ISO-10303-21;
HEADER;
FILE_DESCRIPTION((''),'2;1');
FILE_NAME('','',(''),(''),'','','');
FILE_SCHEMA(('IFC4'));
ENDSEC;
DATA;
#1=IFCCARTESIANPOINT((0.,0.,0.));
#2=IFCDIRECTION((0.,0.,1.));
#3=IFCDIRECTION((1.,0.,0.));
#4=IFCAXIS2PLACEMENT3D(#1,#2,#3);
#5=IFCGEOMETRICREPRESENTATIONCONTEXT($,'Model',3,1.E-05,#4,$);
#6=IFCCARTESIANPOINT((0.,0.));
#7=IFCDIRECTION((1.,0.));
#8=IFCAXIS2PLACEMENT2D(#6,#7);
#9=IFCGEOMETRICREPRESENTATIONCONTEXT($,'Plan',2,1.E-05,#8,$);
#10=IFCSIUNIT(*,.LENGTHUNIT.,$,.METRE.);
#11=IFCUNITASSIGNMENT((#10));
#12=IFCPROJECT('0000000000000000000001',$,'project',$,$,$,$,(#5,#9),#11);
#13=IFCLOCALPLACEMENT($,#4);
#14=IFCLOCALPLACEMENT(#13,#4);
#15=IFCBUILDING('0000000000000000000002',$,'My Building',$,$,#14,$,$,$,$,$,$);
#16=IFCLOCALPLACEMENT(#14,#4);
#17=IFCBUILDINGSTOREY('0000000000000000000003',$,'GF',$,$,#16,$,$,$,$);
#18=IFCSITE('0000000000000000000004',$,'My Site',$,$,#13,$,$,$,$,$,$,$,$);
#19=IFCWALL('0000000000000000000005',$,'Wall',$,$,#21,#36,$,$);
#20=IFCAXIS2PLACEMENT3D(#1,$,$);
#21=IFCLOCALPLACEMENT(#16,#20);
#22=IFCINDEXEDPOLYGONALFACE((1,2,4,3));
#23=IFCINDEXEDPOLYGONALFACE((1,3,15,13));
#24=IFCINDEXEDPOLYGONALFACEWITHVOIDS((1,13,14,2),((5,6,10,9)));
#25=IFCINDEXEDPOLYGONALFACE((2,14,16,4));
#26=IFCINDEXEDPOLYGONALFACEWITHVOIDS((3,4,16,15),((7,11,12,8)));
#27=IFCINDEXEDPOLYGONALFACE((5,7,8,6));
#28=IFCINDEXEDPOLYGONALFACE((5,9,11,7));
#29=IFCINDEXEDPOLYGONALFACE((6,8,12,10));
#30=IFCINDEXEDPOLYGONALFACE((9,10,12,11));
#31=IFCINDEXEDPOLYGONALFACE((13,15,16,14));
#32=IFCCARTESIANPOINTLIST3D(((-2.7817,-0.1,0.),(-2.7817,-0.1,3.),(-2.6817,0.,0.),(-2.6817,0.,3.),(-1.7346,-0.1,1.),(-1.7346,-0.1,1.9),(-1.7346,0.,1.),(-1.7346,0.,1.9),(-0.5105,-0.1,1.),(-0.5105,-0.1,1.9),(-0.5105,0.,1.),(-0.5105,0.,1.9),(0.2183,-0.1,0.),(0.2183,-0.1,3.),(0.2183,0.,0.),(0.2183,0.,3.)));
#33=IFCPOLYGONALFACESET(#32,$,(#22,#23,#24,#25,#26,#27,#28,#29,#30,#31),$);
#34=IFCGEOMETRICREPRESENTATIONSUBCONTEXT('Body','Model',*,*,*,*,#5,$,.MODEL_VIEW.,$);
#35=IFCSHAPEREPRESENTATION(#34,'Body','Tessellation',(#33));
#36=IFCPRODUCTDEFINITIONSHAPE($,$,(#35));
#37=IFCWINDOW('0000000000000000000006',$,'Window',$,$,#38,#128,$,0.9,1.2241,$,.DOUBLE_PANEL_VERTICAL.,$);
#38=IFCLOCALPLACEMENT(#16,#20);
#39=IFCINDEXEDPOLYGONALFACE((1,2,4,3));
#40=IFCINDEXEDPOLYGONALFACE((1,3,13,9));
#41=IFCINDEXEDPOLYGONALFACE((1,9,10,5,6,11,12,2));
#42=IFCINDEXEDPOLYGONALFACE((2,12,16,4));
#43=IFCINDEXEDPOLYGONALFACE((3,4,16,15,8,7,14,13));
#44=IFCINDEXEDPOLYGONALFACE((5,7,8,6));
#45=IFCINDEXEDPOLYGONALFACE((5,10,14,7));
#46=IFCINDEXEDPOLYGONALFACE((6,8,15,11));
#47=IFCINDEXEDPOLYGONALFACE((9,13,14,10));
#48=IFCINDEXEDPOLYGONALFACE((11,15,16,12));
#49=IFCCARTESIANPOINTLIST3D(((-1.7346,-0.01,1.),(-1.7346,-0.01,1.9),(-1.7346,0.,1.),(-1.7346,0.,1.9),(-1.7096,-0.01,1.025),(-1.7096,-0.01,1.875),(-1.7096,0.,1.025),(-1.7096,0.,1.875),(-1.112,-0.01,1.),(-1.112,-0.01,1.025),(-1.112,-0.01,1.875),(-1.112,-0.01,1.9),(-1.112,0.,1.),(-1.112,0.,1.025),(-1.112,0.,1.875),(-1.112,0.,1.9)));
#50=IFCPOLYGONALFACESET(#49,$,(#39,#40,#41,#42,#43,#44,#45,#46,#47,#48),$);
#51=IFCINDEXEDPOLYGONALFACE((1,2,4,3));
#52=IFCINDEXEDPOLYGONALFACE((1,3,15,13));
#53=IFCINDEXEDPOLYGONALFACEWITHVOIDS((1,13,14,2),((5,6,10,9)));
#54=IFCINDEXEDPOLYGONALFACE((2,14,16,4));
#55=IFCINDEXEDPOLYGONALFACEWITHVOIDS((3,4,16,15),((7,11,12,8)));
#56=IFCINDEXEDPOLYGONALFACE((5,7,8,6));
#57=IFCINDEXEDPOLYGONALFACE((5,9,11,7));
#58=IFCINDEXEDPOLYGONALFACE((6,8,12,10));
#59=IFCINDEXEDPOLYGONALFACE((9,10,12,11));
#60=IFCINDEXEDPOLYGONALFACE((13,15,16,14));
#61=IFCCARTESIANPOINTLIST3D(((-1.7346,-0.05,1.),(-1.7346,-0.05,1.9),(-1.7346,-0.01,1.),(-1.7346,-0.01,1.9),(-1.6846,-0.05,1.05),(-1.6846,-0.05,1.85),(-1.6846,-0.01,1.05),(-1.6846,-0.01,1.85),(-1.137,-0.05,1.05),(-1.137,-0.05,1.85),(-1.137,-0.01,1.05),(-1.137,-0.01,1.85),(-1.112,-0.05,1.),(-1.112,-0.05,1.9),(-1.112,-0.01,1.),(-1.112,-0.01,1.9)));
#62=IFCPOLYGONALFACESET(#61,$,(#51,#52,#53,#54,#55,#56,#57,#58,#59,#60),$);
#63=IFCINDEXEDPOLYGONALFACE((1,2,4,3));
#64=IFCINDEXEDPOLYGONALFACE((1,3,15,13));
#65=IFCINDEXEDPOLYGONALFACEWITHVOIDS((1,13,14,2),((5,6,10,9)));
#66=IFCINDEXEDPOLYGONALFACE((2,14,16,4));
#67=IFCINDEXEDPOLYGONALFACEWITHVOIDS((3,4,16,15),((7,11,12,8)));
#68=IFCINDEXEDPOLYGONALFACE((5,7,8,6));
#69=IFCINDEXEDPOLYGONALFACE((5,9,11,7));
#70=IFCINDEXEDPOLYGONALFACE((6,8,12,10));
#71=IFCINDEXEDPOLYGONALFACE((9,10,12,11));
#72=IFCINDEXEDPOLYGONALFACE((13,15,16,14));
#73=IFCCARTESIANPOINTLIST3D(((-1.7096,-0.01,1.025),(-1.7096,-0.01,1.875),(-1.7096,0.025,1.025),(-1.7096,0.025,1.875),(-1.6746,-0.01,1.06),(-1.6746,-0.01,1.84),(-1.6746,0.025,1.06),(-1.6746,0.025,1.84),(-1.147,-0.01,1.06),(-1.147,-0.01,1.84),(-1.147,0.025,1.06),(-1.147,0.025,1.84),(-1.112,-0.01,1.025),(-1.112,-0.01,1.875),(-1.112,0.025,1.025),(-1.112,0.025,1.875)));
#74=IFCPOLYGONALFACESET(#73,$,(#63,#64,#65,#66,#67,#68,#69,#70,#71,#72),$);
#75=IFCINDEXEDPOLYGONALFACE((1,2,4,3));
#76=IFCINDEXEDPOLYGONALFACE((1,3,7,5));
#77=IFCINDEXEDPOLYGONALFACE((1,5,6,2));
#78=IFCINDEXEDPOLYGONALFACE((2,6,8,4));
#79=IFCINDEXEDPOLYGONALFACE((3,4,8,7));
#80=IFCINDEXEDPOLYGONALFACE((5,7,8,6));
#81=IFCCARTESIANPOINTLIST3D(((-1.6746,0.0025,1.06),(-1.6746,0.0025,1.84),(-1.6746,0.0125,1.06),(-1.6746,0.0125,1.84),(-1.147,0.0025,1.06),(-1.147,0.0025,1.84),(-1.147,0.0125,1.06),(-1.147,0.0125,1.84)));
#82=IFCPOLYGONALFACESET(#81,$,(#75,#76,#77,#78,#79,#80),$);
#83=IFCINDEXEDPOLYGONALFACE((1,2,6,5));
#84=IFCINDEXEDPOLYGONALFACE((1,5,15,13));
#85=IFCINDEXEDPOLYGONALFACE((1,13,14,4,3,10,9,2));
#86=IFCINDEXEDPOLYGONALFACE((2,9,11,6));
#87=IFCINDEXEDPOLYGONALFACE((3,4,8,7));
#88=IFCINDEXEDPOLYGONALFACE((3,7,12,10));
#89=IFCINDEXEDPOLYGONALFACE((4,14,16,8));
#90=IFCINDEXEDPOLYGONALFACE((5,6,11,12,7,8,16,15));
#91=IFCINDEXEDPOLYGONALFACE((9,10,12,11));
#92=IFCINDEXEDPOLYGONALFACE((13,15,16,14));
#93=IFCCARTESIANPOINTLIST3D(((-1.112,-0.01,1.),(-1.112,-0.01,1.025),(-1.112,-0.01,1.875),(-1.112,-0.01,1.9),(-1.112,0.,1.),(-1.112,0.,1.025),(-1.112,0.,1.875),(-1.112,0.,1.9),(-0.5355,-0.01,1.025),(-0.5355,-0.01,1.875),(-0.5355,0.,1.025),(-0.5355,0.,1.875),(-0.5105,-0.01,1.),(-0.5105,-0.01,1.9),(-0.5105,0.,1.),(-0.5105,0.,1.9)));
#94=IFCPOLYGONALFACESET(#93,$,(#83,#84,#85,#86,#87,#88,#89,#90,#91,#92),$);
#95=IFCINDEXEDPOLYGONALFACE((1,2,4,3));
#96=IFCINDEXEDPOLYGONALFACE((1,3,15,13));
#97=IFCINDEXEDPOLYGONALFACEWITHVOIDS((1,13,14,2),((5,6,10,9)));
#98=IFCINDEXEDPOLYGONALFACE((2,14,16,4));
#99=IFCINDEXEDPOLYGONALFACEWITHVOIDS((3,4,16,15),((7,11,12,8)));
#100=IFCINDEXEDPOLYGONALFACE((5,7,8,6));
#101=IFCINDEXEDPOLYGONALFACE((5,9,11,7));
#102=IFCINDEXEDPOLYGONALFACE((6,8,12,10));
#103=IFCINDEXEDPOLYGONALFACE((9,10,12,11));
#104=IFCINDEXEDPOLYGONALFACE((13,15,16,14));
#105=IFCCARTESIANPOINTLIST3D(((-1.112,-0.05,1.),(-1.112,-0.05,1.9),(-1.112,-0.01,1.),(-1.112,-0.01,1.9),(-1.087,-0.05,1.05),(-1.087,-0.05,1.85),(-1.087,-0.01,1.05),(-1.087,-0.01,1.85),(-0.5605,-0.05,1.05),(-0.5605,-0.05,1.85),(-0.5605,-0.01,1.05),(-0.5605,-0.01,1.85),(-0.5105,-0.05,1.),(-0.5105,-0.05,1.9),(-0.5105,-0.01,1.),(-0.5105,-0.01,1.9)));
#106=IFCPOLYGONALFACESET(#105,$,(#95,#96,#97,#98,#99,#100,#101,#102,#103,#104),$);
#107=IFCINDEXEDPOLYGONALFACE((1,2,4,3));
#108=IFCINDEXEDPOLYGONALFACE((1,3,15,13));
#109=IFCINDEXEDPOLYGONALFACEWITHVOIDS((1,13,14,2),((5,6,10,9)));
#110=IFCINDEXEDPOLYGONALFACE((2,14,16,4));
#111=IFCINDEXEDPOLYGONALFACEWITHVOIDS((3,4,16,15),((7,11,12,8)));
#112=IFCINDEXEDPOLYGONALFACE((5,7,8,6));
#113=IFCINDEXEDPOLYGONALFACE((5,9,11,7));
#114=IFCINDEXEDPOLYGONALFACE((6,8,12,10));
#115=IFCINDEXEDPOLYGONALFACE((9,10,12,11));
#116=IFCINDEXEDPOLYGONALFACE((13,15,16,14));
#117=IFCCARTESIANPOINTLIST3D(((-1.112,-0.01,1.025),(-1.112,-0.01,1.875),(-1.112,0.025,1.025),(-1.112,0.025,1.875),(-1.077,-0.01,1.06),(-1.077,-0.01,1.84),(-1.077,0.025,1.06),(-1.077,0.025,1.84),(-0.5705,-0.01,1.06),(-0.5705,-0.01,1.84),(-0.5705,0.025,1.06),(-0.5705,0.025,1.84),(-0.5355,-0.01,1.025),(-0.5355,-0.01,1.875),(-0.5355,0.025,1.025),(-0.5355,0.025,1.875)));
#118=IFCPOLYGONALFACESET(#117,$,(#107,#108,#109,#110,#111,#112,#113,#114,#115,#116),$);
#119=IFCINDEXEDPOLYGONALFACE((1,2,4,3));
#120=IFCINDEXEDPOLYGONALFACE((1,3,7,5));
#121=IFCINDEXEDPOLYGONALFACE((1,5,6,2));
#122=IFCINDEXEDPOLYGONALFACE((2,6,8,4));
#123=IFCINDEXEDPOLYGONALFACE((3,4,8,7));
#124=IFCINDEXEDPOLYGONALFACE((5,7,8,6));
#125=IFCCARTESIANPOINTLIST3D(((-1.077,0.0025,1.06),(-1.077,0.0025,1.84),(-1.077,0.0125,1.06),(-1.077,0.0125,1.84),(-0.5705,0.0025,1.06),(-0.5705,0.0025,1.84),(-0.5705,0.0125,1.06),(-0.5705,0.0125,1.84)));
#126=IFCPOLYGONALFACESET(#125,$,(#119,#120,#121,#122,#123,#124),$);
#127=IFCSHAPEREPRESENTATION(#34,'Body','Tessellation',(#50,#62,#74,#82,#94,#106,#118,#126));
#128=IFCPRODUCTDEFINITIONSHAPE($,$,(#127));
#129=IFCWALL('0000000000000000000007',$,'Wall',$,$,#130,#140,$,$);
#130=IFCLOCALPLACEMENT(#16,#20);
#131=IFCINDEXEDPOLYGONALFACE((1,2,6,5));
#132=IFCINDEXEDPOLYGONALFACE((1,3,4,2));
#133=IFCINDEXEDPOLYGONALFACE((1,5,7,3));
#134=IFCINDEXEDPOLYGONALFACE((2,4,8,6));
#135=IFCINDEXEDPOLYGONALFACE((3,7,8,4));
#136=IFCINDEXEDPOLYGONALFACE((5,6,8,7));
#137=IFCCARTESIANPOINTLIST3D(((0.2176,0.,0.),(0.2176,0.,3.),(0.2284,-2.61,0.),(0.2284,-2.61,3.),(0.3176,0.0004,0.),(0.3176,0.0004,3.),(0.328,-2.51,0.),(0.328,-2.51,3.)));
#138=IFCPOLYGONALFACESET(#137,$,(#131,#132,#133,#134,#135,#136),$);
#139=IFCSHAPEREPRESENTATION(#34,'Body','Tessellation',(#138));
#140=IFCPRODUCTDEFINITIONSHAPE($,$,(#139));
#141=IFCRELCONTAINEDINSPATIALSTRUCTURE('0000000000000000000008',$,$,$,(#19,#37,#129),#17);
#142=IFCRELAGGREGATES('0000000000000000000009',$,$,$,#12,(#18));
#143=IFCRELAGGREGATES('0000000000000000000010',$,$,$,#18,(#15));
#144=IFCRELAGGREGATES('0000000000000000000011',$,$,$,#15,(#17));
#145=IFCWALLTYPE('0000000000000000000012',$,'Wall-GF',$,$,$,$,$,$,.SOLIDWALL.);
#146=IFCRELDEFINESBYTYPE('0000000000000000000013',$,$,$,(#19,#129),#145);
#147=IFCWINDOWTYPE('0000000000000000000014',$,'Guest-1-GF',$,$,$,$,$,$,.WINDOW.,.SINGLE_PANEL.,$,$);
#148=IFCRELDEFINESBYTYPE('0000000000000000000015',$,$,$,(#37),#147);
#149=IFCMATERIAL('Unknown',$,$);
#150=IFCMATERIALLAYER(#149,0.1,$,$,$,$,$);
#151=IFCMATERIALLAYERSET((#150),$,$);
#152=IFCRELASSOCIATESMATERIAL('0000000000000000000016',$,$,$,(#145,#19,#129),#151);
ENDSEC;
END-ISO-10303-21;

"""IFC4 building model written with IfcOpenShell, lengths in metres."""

from ifc_helpers import new_model, entity, si_unit, frame, origin_with_axes, origin_2d_with_axis, place, context, subcontext, project, spatial, line, indexed_curve, outline, extrude, shape, source, transform, mapped, material, layer, layer_set, layer_usage, type_object, type_shapes, element, fill, save


model = new_model("IFC4")

# Units and contexts
model_context = context("Model", 3, precision=1e-05, world=origin_with_axes())
plan_context = context("Plan", 2, precision=1e-05, world=origin_2d_with_axis())
body_context_1 = subcontext(model_context, "Body", "Model", "MODEL_VIEW")
body_context_2 = subcontext(plan_context, "Body", "Plan", "PLAN_VIEW")
ifc_project = project(units=[si_unit("LENGTHUNIT", "METRE")], contexts=[model_context, plan_context])

# Site, building, storey
site_placement = place(None, origin_with_axes())
site = spatial("IfcSite", under=ifc_project, at=site_placement, Name="My Site")
building_placement = place(site_placement, origin_with_axes())
building = spatial("IfcBuilding", under=site, at=building_placement, Name="My Building")
storey_placement = place(building_placement, origin_with_axes())
storey = spatial("IfcBuildingStorey", under=building, at=storey_placement, Name="GF")

# Shared definitions
ifc_material = material(Name="Unknown")

# Shared definitions
ifc_layer_1 = layer(ifc_material, 0.1)
ifc_layer_set_1 = layer_set([ifc_layer_1])
wall_type = type_object("IfcWallType", Name="Wall-GF", PredefinedType="SOLIDWALL", material=ifc_layer_set_1)

# Wall, opening, window
ifc_layer_usage_1 = layer_usage(ifc_layer_set_1, "AXIS2", "POSITIVE", 0.0)
wall_1_placement = place(storey_placement, frame((-2.7817, -0.1, 0.0), z_axis=(0.0, 0.0, 1.0), x_axis=(1.0, 0.0, 0.0)))
wall_1 = element("IfcWall", 1, at=wall_1_placement, inside=storey, type_object=wall_type, material=ifc_layer_usage_1, Name="Wall", context=body_context_1, shape_type="SweptSolid", body=[
    extrude(outline(indexed_curve([(0.0, 0.0), (0.1, 0.1), (3.0, 0.1), (3.0, 0.0)], segments=[line(1, 2, 3, 4, 1)])), origin_with_axes(), (0.0, 0.0, 1.0), 3.0),
])
shared_shape_1 = source(origin_with_axes(), body_context_1, "Body", "SweptSolid", [
    extrude(outline(indexed_curve([(0.0, 0.0), (1.2241, 0.0), (1.2241, 0.9), (0.0, 0.9)], segments=[line(1, 2, 3, 4, 1)])), frame((0.0, -0.6, 0.0), z_axis=(0.0, -1.0, 0.0), x_axis=(1.0, 0.0, 0.0)), (0.0, 0.0, -1.0), 1.2),
])
opening_1_placement = place(wall_1_placement, frame((1.0471, 0.0, 1.0), z_axis=(0.0, 0.0, 1.0), x_axis=(1.0, 0.0, 0.0)))
opening_1 = element("IfcOpeningElement", 2, at=opening_1_placement, cuts=wall_1, PredefinedType="OPENING", context=body_context_1, shape_type="MappedRepresentation", body=[
    mapped(shared_shape_1, transform((0.0, 0.0, 0.0), x_axis=(1.0, 0.0, 0.0), y_axis=(0.0, 1.0, 0.0), z_axis=(0.0, 0.0, 1.0), scale=1.0)),
])
window_type_1 = type_object("IfcWindowType", Name="Guest-1-GF", PartitioningType="SINGLE_PANEL", PredefinedType="WINDOW")
shared_shape_2 = source(origin_with_axes(), body_context_1, "Body", "SweptSolid", [
    extrude(outline(indexed_curve([(0.6225, 0.0), (0.0, 0.0), (0.0, 0.9), (0.6225, 0.9), (0.6225, 0.875), (0.025, 0.875), (0.025, 0.025), (0.6225, 0.025)], segments=[line(1, 2, 3, 4, 5, 6, 7, 8, 1)])), frame((0.0, 0.09, 0.0), z_axis=(0.0, -1.0, 0.0), x_axis=(1.0, 0.0, 0.0)), (0.0, 0.0, -1.0), 0.01),
    extrude(outline(indexed_curve([(0.0, 0.0), (0.6225, 0.0), (0.6225, 0.9), (0.0, 0.9)], segments=[line(1, 2, 3, 4, 1)]), holes=[indexed_curve([(0.05, 0.05), (0.5975, 0.05), (0.5975, 0.85), (0.05, 0.85)], segments=[line(1, 2, 3, 4, 1)])]), frame((0.0, 0.05, 0.0), z_axis=(0.0, -1.0, 0.0), x_axis=(1.0, 0.0, 0.0)), (0.0, 0.0, -1.0), 0.04),
    extrude(outline(indexed_curve([(0.0, 0.0), (0.5975, 0.0), (0.5975, 0.85), (0.0, 0.85)], segments=[line(1, 2, 3, 4, 1)]), holes=[indexed_curve([(0.035, 0.035), (0.5625, 0.035), (0.5625, 0.815), (0.035, 0.815)], segments=[line(1, 2, 3, 4, 1)])]), frame((0.025, 0.09, 0.025), z_axis=(0.0, -1.0, 0.0), x_axis=(1.0, 0.0, 0.0)), (0.0, 0.0, -1.0), 0.035),
    extrude(outline(indexed_curve([(0.035, 0.035), (0.5625, 0.035), (0.5625, 0.815), (0.035, 0.815)], segments=[line(1, 2, 3, 4, 1)])), frame((0.025, 0.1025, 0.025), z_axis=(0.0, -1.0, 0.0), x_axis=(1.0, 0.0, 0.0)), (0.0, 0.0, -1.0), 0.01),
    extrude(outline(indexed_curve([(0.0, 0.9), (0.6016, 0.9), (0.6016, 0.0), (0.0, 0.0), (0.0, 0.025), (0.5766, 0.025), (0.5766, 0.875), (0.0, 0.875)], segments=[line(1, 2, 3, 4, 5, 6, 7, 8, 1)])), frame((0.6225, 0.09, 0.0), z_axis=(0.0, -1.0, 0.0), x_axis=(1.0, 0.0, 0.0)), (0.0, 0.0, -1.0), 0.01),
    extrude(outline(indexed_curve([(0.0, 0.0), (0.6016, 0.0), (0.6016, 0.9), (0.0, 0.9)], segments=[line(1, 2, 3, 4, 1)]), holes=[indexed_curve([(0.025, 0.05), (0.5516, 0.05), (0.5516, 0.85), (0.025, 0.85)], segments=[line(1, 2, 3, 4, 1)])]), frame((0.6225, 0.05, 0.0), z_axis=(0.0, -1.0, 0.0), x_axis=(1.0, 0.0, 0.0)), (0.0, 0.0, -1.0), 0.04),
    extrude(outline(indexed_curve([(0.0, 0.0), (0.5766, 0.0), (0.5766, 0.85), (0.0, 0.85)], segments=[line(1, 2, 3, 4, 1)]), holes=[indexed_curve([(0.035, 0.035), (0.5416, 0.035), (0.5416, 0.815), (0.035, 0.815)], segments=[line(1, 2, 3, 4, 1)])]), frame((0.6225, 0.09, 0.025), z_axis=(0.0, -1.0, 0.0), x_axis=(1.0, 0.0, 0.0)), (0.0, 0.0, -1.0), 0.035),
    extrude(outline(indexed_curve([(0.035, 0.035), (0.5416, 0.035), (0.5416, 0.815), (0.035, 0.815)], segments=[line(1, 2, 3, 4, 1)])), frame((0.6225, 0.1025, 0.025), z_axis=(0.0, -1.0, 0.0), x_axis=(1.0, 0.0, 0.0)), (0.0, 0.0, -1.0), 0.01),
])
shared_shape_3 = source(origin_with_axes(), body_context_2, "Body", "Curve2D", [
    entity("IfcIndexedPolyCurve", entity("IfcCartesianPointList2D", [[0.05, 0.05], [0.5975, 0.05]])),
    entity("IfcIndexedPolyCurve", entity("IfcCartesianPointList2D", [[0.0, 0.1], [0.025, 0.1], [0.025, 0.09], [0.05, 0.09], [0.05, 0.05], [0.0, 0.05]]), [entity("IfcLineIndex", [1, 2, 3, 4, 5, 6, 1])]),
    entity("IfcIndexedPolyCurve", entity("IfcCartesianPointList2D", [[0.6225, 0.1], [0.6225, 0.1], [0.6225, 0.09], [0.5975, 0.09], [0.5975, 0.05], [0.6225, 0.05]])),
    entity("IfcIndexedPolyCurve", entity("IfcCartesianPointList2D", [[0.025, 0.09], [0.06, 0.09], [0.06, 0.125], [0.025, 0.125]]), [entity("IfcLineIndex", [1, 2, 3, 4, 1])]),
    entity("IfcIndexedPolyCurve", entity("IfcCartesianPointList2D", [[0.6225, 0.09], [0.5875, 0.09], [0.5875, 0.125], [0.6225, 0.125]]), [entity("IfcLineIndex", [1, 2, 3, 4, 1])]),
    entity("IfcIndexedPolyCurve", entity("IfcCartesianPointList2D", [[0.06, 0.09], [0.5875, 0.09]])),
    entity("IfcIndexedPolyCurve", entity("IfcCartesianPointList2D", [[0.06, 0.125], [0.5875, 0.125]])),
    entity("IfcIndexedPolyCurve", entity("IfcCartesianPointList2D", [[0.06, 0.1075], [0.5875, 0.1075]])),
    entity("IfcIndexedPolyCurve", entity("IfcCartesianPointList2D", [[0.6475, 0.05], [1.1741, 0.05]])),
    entity("IfcIndexedPolyCurve", entity("IfcCartesianPointList2D", [[0.6225, 0.1], [0.6225, 0.1], [0.6225, 0.09], [0.6475, 0.09], [0.6475, 0.05], [0.6225, 0.05]])),
    entity("IfcIndexedPolyCurve", entity("IfcCartesianPointList2D", [[1.2241, 0.1], [1.1991, 0.1], [1.1991, 0.09], [1.1741, 0.09], [1.1741, 0.05], [1.2241, 0.05]]), [entity("IfcLineIndex", [1, 2, 3, 4, 5, 6, 1])]),
    entity("IfcIndexedPolyCurve", entity("IfcCartesianPointList2D", [[0.6225, 0.09], [0.6575, 0.09], [0.6575, 0.125], [0.6225, 0.125]]), [entity("IfcLineIndex", [1, 2, 3, 4, 1])]),
    entity("IfcIndexedPolyCurve", entity("IfcCartesianPointList2D", [[1.1991, 0.09], [1.1641, 0.09], [1.1641, 0.125], [1.1991, 0.125]]), [entity("IfcLineIndex", [1, 2, 3, 4, 1])]),
    entity("IfcIndexedPolyCurve", entity("IfcCartesianPointList2D", [[0.6575, 0.09], [1.1641, 0.09]])),
    entity("IfcIndexedPolyCurve", entity("IfcCartesianPointList2D", [[0.6575, 0.125], [1.1641, 0.125]])),
    entity("IfcIndexedPolyCurve", entity("IfcCartesianPointList2D", [[0.6575, 0.1075], [1.1641, 0.1075]])),
])
type_shapes(window_type_1, [shared_shape_2, shared_shape_3])
window_1_placement = place(opening_1_placement, origin_with_axes())
window_1 = element("IfcWindow", 3, at=window_1_placement, inside=storey, type_object=window_type_1, Name="Window", OverallHeight=0.9, OverallWidth=1.2241, PartitioningType="DOUBLE_PANEL_VERTICAL", shapes=[
    shape(body_context_1, "Body", "MappedRepresentation", [mapped(shared_shape_2, transform((0.0, 0.0, 0.0), x_axis=(1.0, 0.0, 0.0), y_axis=(0.0, 1.0, 0.0), z_axis=(0.0, 0.0, 1.0), scale=1.0))]),
    shape(body_context_2, "Body", "MappedRepresentation", [mapped(shared_shape_3, transform((0.0, 0.0, 0.0), x_axis=(1.0, 0.0, 0.0), y_axis=(0.0, 1.0, 0.0), z_axis=(0.0, 0.0, 1.0), scale=1.0))]),
])
fill(opening_1, window_1)

# Wall
ifc_layer_usage_2 = layer_usage(ifc_layer_set_1, "AXIS2", "POSITIVE", 0.0)
wall_2_placement = place(storey_placement, frame((0.2176, 0.0, 0.0), z_axis=(0.0, 0.0, 1.0), x_axis=(0.004129, -0.999991, 0.0)))
element("IfcWall", 4, at=wall_2_placement, inside=storey, type_object=wall_type, material=ifc_layer_usage_2, Name="Wall", context=body_context_1, shape_type="SweptSolid", body=[
    extrude(outline(indexed_curve([(0.0, 0.0), (0.0, 0.1), (2.5104, 0.1), (2.61, 0.0)], segments=[line(1, 2, 3, 4, 1)])), origin_with_axes(), (0.0, 0.0, 1.0), 3.0),
])

save(model, "model.ifc")
